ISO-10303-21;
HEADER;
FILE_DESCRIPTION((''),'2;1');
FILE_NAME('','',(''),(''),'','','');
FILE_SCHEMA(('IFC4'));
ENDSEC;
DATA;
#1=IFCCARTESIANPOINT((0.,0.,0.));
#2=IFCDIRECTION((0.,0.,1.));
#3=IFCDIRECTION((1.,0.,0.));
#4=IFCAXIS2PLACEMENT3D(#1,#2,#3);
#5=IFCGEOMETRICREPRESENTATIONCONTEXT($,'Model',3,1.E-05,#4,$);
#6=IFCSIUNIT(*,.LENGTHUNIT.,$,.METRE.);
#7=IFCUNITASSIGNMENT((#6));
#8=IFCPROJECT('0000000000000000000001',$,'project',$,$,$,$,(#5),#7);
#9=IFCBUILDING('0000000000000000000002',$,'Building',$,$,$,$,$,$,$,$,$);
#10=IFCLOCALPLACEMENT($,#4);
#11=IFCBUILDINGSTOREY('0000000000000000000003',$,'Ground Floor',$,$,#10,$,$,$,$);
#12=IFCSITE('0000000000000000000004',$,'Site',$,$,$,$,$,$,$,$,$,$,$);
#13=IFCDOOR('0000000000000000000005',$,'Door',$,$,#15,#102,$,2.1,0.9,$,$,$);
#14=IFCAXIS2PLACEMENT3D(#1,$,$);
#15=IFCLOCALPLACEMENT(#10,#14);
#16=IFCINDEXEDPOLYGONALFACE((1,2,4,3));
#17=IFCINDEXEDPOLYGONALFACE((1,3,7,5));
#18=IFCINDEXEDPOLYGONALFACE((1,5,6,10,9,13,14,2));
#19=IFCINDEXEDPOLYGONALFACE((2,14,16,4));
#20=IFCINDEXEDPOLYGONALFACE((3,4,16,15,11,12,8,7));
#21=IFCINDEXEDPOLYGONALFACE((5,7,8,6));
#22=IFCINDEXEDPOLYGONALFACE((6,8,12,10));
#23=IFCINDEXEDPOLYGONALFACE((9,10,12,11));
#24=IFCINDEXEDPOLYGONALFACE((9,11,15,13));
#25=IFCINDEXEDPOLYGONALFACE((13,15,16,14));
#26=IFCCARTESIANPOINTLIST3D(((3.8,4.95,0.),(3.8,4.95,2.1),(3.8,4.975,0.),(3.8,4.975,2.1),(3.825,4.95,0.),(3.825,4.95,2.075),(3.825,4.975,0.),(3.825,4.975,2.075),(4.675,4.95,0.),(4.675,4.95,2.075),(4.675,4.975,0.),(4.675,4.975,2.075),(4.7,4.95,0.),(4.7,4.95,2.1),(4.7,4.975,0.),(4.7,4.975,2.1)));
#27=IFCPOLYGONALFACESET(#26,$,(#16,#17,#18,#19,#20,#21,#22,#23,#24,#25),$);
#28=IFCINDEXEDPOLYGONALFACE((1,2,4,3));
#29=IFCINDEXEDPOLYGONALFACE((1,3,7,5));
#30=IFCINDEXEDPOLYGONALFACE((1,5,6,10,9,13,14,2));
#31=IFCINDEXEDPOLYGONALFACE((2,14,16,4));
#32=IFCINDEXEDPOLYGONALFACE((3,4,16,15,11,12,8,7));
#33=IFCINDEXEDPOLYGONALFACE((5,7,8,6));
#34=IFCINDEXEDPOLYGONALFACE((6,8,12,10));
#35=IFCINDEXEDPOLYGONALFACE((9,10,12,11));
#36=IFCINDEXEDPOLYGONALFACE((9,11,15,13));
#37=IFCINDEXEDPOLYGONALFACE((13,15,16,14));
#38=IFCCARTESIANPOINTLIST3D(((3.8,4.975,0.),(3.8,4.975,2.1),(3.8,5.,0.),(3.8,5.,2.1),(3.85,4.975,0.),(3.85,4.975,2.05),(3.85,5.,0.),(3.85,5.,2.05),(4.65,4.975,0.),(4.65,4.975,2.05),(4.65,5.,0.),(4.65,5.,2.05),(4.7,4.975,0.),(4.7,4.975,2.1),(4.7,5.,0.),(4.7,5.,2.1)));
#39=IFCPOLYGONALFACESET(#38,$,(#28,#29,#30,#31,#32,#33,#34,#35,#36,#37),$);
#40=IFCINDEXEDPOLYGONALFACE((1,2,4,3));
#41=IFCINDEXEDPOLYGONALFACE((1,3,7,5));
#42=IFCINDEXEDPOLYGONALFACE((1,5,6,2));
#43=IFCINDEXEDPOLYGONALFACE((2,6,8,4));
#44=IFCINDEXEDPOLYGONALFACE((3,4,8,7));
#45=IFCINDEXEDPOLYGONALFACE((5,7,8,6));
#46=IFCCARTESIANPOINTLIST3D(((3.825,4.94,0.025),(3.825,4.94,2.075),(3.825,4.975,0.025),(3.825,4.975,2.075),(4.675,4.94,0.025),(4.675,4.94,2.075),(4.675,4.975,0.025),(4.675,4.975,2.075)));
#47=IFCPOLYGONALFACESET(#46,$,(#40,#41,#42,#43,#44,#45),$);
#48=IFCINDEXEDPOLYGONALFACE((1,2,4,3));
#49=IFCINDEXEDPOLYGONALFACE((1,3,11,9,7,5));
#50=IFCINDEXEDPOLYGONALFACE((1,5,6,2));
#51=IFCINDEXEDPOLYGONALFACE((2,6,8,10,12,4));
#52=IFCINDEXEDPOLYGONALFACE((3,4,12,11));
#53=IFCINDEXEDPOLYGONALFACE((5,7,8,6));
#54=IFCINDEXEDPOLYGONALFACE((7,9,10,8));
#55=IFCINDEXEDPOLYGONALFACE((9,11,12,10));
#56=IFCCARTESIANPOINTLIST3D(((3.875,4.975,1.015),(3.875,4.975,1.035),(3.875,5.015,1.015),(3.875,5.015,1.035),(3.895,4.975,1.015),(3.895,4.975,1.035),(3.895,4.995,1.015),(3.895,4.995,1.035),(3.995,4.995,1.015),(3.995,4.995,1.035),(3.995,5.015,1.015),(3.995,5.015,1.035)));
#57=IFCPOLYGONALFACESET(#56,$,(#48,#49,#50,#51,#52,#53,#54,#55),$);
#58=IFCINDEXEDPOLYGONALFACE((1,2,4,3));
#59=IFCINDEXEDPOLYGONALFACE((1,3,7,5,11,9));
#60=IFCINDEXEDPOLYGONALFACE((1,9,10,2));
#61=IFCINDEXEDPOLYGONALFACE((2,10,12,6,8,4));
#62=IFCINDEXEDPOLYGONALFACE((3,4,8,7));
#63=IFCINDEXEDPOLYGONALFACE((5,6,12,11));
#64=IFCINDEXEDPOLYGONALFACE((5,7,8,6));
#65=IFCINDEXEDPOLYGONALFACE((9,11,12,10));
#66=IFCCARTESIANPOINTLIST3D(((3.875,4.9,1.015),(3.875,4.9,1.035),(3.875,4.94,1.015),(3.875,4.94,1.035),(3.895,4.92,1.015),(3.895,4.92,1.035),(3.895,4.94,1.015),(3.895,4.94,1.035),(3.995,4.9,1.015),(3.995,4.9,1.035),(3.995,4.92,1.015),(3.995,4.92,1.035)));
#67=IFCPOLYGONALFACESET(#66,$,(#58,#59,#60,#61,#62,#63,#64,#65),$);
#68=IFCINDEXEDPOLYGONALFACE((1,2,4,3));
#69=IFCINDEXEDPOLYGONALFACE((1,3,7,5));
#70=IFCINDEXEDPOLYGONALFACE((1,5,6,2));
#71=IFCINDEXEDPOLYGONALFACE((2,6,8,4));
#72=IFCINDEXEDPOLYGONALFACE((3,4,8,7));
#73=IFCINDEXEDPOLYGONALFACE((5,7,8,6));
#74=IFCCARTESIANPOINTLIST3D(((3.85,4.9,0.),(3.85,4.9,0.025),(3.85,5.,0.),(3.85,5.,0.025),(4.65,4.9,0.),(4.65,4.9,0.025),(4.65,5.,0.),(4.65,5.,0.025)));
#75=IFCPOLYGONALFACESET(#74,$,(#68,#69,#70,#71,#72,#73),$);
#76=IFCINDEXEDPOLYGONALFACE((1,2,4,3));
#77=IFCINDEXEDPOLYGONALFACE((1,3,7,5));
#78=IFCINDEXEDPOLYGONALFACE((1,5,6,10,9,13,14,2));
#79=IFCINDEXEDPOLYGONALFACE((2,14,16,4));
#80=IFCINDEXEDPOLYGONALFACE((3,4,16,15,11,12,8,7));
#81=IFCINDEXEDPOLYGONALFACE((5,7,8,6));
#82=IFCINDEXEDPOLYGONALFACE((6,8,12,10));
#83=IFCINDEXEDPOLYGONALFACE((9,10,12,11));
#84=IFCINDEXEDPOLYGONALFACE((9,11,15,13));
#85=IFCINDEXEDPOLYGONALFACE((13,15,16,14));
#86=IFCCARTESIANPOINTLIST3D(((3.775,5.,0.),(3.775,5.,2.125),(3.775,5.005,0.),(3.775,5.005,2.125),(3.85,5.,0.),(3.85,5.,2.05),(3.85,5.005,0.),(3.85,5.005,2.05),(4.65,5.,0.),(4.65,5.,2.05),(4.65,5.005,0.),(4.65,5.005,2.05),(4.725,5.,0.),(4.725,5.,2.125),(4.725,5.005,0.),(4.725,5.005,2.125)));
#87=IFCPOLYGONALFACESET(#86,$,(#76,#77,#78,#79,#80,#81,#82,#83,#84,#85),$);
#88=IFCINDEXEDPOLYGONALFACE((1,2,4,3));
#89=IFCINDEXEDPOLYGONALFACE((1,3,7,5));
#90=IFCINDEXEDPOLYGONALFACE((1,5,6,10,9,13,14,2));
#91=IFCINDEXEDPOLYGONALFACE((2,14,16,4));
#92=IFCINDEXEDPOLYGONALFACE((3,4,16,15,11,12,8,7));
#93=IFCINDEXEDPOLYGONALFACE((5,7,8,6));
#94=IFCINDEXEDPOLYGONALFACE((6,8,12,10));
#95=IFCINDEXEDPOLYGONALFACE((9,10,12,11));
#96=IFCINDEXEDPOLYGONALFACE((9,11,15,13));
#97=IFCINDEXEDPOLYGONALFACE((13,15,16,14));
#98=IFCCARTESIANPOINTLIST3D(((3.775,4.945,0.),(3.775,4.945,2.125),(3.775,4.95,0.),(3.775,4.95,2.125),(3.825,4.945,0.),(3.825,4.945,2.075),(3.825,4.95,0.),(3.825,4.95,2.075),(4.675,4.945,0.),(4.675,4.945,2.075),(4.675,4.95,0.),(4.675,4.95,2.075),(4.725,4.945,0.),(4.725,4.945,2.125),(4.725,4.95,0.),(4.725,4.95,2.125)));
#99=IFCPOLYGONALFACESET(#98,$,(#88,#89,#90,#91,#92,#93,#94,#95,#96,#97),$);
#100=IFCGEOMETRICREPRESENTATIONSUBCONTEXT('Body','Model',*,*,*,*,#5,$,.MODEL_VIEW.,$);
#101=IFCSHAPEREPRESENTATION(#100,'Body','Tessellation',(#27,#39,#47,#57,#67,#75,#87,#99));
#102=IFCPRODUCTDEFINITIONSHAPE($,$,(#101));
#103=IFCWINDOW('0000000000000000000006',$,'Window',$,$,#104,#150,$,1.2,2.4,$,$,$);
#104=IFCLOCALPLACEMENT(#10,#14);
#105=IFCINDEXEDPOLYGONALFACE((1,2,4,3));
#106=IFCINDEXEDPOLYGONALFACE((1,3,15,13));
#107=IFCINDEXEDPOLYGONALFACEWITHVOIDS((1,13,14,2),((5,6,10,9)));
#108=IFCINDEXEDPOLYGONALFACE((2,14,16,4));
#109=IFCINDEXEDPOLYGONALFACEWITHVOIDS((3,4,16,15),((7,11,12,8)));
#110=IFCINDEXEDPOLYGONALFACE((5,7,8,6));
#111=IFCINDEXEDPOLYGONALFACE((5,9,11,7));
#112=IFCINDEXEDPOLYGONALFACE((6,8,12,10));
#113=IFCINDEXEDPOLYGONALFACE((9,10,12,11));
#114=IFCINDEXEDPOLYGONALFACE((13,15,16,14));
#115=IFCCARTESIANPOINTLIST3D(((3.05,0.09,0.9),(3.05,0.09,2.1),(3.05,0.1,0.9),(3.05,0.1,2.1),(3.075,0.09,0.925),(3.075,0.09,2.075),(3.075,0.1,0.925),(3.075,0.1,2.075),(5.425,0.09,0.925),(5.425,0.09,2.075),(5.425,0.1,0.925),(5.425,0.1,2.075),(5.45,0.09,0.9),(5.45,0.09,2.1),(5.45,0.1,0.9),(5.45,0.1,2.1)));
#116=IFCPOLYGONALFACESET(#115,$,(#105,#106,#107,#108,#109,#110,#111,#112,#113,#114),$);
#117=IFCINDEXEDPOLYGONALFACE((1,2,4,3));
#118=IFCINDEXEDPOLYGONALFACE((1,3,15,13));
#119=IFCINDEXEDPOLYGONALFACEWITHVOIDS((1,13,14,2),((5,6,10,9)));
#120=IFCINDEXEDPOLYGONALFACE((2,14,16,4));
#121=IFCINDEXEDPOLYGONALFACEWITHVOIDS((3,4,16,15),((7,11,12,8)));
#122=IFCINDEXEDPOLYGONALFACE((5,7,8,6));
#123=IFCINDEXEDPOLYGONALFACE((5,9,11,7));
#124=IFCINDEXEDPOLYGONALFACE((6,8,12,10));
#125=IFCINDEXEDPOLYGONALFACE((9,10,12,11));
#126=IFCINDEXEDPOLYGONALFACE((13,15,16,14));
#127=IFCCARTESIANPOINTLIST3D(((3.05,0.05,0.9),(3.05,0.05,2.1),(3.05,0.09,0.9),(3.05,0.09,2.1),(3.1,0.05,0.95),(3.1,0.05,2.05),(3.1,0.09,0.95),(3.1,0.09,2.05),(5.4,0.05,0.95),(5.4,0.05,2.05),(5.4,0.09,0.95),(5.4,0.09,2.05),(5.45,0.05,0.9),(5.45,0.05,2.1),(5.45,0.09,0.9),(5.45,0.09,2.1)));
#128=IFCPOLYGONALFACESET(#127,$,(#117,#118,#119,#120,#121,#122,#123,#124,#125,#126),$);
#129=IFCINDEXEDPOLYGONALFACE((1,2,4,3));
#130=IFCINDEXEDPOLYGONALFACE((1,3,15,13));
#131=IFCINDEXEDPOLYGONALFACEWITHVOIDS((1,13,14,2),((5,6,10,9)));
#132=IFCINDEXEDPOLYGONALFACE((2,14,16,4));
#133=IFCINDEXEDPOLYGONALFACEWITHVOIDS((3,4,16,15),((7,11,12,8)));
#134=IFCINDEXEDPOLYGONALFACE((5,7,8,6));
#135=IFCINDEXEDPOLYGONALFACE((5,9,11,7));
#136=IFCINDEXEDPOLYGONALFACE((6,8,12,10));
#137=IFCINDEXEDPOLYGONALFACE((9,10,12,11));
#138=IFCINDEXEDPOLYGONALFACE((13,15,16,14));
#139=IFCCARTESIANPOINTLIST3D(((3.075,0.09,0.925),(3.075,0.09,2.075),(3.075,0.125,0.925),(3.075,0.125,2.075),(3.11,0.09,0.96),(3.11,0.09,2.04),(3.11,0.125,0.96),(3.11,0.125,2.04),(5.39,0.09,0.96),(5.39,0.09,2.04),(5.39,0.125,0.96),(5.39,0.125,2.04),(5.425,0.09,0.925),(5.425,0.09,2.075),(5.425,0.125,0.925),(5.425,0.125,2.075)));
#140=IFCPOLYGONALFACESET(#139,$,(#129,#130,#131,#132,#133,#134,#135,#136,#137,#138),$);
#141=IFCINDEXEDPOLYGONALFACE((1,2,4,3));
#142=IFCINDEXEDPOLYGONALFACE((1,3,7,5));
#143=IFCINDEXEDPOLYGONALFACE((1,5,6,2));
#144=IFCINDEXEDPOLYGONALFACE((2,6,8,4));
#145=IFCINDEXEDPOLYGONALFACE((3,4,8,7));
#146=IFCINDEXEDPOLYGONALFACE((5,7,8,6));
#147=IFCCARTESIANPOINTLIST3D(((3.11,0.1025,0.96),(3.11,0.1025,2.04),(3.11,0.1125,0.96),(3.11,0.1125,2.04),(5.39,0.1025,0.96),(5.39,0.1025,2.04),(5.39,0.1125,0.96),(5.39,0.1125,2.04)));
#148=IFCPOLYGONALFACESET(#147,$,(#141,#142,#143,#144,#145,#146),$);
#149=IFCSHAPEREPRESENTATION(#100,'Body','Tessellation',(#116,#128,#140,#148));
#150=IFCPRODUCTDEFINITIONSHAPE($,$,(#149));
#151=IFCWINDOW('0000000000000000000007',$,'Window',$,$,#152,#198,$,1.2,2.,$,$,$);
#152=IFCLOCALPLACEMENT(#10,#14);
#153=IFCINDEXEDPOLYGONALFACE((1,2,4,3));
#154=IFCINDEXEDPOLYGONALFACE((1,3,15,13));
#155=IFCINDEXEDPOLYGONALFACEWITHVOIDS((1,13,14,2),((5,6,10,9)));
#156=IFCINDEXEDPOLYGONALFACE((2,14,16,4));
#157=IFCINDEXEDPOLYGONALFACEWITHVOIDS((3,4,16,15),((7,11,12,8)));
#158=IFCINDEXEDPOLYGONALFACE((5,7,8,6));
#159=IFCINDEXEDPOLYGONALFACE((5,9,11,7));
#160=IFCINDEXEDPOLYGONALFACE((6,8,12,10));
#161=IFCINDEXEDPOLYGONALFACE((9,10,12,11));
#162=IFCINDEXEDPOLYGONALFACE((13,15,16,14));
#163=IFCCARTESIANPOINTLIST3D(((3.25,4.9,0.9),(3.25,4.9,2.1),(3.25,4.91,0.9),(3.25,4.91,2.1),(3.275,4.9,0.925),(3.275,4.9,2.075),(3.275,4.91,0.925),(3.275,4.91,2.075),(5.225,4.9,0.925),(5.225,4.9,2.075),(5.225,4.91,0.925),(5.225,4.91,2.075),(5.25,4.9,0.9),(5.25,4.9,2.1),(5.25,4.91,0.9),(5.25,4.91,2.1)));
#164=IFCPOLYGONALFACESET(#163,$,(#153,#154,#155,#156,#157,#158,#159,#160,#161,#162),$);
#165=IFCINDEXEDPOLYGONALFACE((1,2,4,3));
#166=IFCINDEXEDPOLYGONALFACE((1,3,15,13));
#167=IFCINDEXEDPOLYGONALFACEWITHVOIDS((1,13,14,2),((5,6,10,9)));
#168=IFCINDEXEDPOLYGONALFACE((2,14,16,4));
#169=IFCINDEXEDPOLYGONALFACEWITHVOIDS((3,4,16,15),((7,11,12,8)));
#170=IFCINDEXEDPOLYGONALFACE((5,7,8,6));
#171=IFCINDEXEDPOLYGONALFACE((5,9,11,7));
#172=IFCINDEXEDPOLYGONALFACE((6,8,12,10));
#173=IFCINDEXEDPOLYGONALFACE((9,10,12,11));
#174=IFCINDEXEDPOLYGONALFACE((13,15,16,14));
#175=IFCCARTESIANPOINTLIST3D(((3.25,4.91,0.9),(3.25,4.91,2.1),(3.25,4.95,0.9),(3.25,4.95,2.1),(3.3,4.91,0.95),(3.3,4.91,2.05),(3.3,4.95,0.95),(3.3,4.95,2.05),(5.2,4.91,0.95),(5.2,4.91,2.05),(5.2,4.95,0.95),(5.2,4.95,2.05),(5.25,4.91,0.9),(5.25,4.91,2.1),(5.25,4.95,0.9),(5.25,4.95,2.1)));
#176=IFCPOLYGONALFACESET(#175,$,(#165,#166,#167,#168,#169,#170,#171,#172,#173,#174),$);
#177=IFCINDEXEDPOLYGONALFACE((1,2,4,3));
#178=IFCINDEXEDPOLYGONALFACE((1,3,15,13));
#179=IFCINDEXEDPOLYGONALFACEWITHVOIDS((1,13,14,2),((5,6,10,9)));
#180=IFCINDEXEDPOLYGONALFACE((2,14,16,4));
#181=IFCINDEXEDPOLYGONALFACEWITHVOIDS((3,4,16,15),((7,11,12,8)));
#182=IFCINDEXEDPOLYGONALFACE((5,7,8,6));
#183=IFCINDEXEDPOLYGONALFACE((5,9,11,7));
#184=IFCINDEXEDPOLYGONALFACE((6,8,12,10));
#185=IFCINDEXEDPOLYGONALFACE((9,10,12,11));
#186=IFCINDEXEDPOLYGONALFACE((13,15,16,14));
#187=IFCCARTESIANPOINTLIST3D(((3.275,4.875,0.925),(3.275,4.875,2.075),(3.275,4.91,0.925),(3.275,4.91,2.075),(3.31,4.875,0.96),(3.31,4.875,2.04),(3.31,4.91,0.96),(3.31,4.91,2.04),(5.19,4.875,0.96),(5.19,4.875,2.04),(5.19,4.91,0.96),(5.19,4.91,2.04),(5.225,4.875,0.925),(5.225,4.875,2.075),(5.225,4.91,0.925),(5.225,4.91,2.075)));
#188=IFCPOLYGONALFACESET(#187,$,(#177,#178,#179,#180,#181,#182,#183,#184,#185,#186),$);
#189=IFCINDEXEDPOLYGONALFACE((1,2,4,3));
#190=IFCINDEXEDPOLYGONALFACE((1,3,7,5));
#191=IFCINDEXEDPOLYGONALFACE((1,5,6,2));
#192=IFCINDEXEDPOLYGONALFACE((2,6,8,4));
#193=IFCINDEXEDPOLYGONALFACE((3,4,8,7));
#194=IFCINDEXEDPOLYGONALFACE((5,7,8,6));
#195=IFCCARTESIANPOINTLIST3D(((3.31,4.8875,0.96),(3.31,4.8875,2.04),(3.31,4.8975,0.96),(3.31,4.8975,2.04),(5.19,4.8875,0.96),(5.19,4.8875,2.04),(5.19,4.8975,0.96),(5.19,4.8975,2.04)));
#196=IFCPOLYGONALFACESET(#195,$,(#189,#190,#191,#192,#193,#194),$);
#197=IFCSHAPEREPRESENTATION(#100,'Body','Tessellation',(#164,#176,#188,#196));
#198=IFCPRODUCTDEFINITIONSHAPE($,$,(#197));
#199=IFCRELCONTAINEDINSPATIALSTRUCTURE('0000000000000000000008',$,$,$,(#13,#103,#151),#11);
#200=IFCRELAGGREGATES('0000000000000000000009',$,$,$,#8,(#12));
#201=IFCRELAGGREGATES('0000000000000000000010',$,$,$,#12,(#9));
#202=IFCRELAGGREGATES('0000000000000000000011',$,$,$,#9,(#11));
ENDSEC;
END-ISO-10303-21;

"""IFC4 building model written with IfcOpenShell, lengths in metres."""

from ifc_helpers import new_model, si_unit, frame, origin_with_axes, place, context, subcontext, project, spatial, line, indexed_curve, outline, extrude, element, save


model = new_model("IFC4")

# Units and contexts
model_context = context("Model", 3, precision=1e-05, world=origin_with_axes())
body_context = subcontext(model_context, "Body", "Model", "MODEL_VIEW")
ifc_project = project(units=[si_unit("LENGTHUNIT", "METRE")], contexts=[model_context])

# Site, building, storey
site = spatial("IfcSite", under=ifc_project, Name="Site")
building = spatial("IfcBuilding", under=site, Name="Building")
storey_placement = place(None, origin_with_axes())
storey = spatial("IfcBuildingStorey", under=building, at=storey_placement, Name="Ground Floor")

# Door
door_1_placement = place(storey_placement, frame((4.7, 5.0, 0.0), z_axis=(0.0, 0.0, 1.0), x_axis=(-1.0, 0.0, 0.0)))
element("IfcDoor", 1, at=door_1_placement, inside=storey, Name="Door", OverallHeight=2.1, OverallWidth=0.9, context=body_context, shape_type="SweptSolid", body=[
    extrude(outline(indexed_curve([(0.0, 0.0), (0.0, 2.1), (0.9, 2.1), (0.9, 0.0), (0.875, 0.0), (0.875, 2.075), (0.025, 2.075), (0.025, 0.0)], segments=[line(1, 2, 3, 4, 5, 6, 7, 8, 1)])), frame((0.0, 0.025, 0.0), z_axis=(0.0, -1.0, 0.0), x_axis=(1.0, 0.0, 0.0)), (0.0, 0.0, -1.0), 0.025),
    extrude(outline(indexed_curve([(0.0, 0.0), (0.0, 2.1), (0.9, 2.1), (0.9, 0.0), (0.85, 0.0), (0.85, 2.05), (0.05, 2.05), (0.05, 0.0)], segments=[line(1, 2, 3, 4, 5, 6, 7, 8, 1)])), frame((0.0, 0.0, 0.0), z_axis=(0.0, -1.0, 0.0), x_axis=(1.0, 0.0, 0.0)), (0.0, 0.0, -1.0), 0.025),
    extrude(outline(indexed_curve([(0.0, 0.0), (0.85, 0.0), (0.85, 0.035), (0.0, 0.035)], segments=[line(1, 2, 3, 4, 1)])), frame((0.025, 0.025, 0.025), z_axis=(0.0, 0.0, 1.0), x_axis=(1.0, 0.0, 0.0)), (0.0, 0.0, 1.0), 2.05),
    extrude(outline(indexed_curve([(0.0, 0.0), (0.0, -0.04), (-0.12, -0.04), (-0.12, -0.02), (-0.02, -0.02), (-0.02, 0.0)], segments=[line(1, 2, 3, 4, 5, 6, 1)])), frame((0.825, 0.025, 1.015), z_axis=(0.0, 0.0, 1.0), x_axis=(1.0, 0.0, 0.0)), (0.0, 0.0, 1.0), 0.02),
    extrude(outline(indexed_curve([(0.0, 0.0), (0.0, 0.04), (-0.12, 0.04), (-0.12, 0.02), (-0.02, 0.02), (-0.02, 0.0)], segments=[line(1, 2, 3, 4, 5, 6, 1)])), frame((0.825, 0.06, 1.015), z_axis=(0.0, 0.0, 1.0), x_axis=(1.0, 0.0, 0.0)), (0.0, 0.0, 1.0), 0.02),
    extrude(outline(indexed_curve([(0.0, 0.0), (0.8, 0.0), (0.8, 0.1), (0.0, 0.1)], segments=[line(1, 2, 3, 4, 1)])), frame((0.05, 0.0, 0.0), z_axis=(0.0, 0.0, 1.0), x_axis=(1.0, 0.0, 0.0)), (0.0, 0.0, 1.0), 0.025),
    extrude(outline(indexed_curve([(0.0, 0.0), (0.0, 2.125), (0.95, 2.125), (0.95, 0.0), (0.875, 0.0), (0.875, 2.05), (0.075, 2.05), (0.075, 0.0)], segments=[line(1, 2, 3, 4, 5, 6, 7, 8, 1)])), frame((-0.025, -0.005, 0.0), z_axis=(0.0, -1.0, 0.0), x_axis=(1.0, 0.0, 0.0)), (0.0, 0.0, -1.0), 0.005),
    extrude(outline(indexed_curve([(0.0, 0.0), (0.0, 2.125), (0.95, 2.125), (0.95, 0.0), (0.9, 0.0), (0.9, 2.075), (0.05, 2.075), (0.05, 0.0)], segments=[line(1, 2, 3, 4, 5, 6, 7, 8, 1)])), frame((-0.025, 0.05, 0.0), z_axis=(0.0, -1.0, 0.0), x_axis=(1.0, 0.0, 0.0)), (0.0, 0.0, -1.0), 0.005),
])

# Windows
window_1_placement = place(storey_placement, frame((3.05, 0.0, 0.9), z_axis=(0.0, 0.0, 1.0), x_axis=(1.0, 0.0, 0.0)))
element("IfcWindow", 2, at=window_1_placement, inside=storey, Name="Window", OverallHeight=1.2, OverallWidth=2.4, context=body_context, shape_type="SweptSolid", body=[
    extrude(outline(indexed_curve([(0.0, 0.0), (2.4, 0.0), (2.4, 1.2), (0.0, 1.2)], segments=[line(1, 2, 3, 4, 1)]), holes=[indexed_curve([(0.025, 0.025), (2.375, 0.025), (2.375, 1.175), (0.025, 1.175)], segments=[line(1, 2, 3, 4, 1)])]), frame((0.0, 0.09, 0.0), z_axis=(0.0, -1.0, 0.0), x_axis=(1.0, 0.0, 0.0)), (0.0, 0.0, -1.0), 0.01),
    extrude(outline(indexed_curve([(0.0, 0.0), (2.4, 0.0), (2.4, 1.2), (0.0, 1.2)], segments=[line(1, 2, 3, 4, 1)]), holes=[indexed_curve([(0.05, 0.05), (2.35, 0.05), (2.35, 1.15), (0.05, 1.15)], segments=[line(1, 2, 3, 4, 1)])]), frame((0.0, 0.05, 0.0), z_axis=(0.0, -1.0, 0.0), x_axis=(1.0, 0.0, 0.0)), (0.0, 0.0, -1.0), 0.04),
    extrude(outline(indexed_curve([(0.0, 0.0), (2.35, 0.0), (2.35, 1.15), (0.0, 1.15)], segments=[line(1, 2, 3, 4, 1)]), holes=[indexed_curve([(0.035, 0.035), (2.315, 0.035), (2.315, 1.115), (0.035, 1.115)], segments=[line(1, 2, 3, 4, 1)])]), frame((0.025, 0.09, 0.025), z_axis=(0.0, -1.0, 0.0), x_axis=(1.0, 0.0, 0.0)), (0.0, 0.0, -1.0), 0.035),
    extrude(outline(indexed_curve([(0.035, 0.035), (2.315, 0.035), (2.315, 1.115), (0.035, 1.115)], segments=[line(1, 2, 3, 4, 1)])), frame((0.025, 0.1025, 0.025), z_axis=(0.0, -1.0, 0.0), x_axis=(1.0, 0.0, 0.0)), (0.0, 0.0, -1.0), 0.01),
])
window_2_placement = place(storey_placement, frame((5.25, 5.0, 0.9), z_axis=(0.0, 0.0, 1.0), x_axis=(-1.0, 0.0, 0.0)))
element("IfcWindow", 3, at=window_2_placement, inside=storey, Name="Window", OverallHeight=1.2, OverallWidth=2.0, context=body_context, shape_type="SweptSolid", body=[
    extrude(outline(indexed_curve([(0.0, 0.0), (2.0, 0.0), (2.0, 1.2), (0.0, 1.2)], segments=[line(1, 2, 3, 4, 1)]), holes=[indexed_curve([(0.025, 0.025), (1.975, 0.025), (1.975, 1.175), (0.025, 1.175)], segments=[line(1, 2, 3, 4, 1)])]), frame((0.0, 0.09, 0.0), z_axis=(0.0, -1.0, 0.0), x_axis=(1.0, 0.0, 0.0)), (0.0, 0.0, -1.0), 0.01),
    extrude(outline(indexed_curve([(0.0, 0.0), (2.0, 0.0), (2.0, 1.2), (0.0, 1.2)], segments=[line(1, 2, 3, 4, 1)]), holes=[indexed_curve([(0.05, 0.05), (1.95, 0.05), (1.95, 1.15), (0.05, 1.15)], segments=[line(1, 2, 3, 4, 1)])]), frame((0.0, 0.05, 0.0), z_axis=(0.0, -1.0, 0.0), x_axis=(1.0, 0.0, 0.0)), (0.0, 0.0, -1.0), 0.04),
    extrude(outline(indexed_curve([(0.0, 0.0), (1.95, 0.0), (1.95, 1.15), (0.0, 1.15)], segments=[line(1, 2, 3, 4, 1)]), holes=[indexed_curve([(0.035, 0.035), (1.915, 0.035), (1.915, 1.115), (0.035, 1.115)], segments=[line(1, 2, 3, 4, 1)])]), frame((0.025, 0.09, 0.025), z_axis=(0.0, -1.0, 0.0), x_axis=(1.0, 0.0, 0.0)), (0.0, 0.0, -1.0), 0.035),
    extrude(outline(indexed_curve([(0.035, 0.035), (1.915, 0.035), (1.915, 1.115), (0.035, 1.115)], segments=[line(1, 2, 3, 4, 1)])), frame((0.025, 0.1025, 0.025), z_axis=(0.0, -1.0, 0.0), x_axis=(1.0, 0.0, 0.0)), (0.0, 0.0, -1.0), 0.01),
])

save(model, "model.ifc")
